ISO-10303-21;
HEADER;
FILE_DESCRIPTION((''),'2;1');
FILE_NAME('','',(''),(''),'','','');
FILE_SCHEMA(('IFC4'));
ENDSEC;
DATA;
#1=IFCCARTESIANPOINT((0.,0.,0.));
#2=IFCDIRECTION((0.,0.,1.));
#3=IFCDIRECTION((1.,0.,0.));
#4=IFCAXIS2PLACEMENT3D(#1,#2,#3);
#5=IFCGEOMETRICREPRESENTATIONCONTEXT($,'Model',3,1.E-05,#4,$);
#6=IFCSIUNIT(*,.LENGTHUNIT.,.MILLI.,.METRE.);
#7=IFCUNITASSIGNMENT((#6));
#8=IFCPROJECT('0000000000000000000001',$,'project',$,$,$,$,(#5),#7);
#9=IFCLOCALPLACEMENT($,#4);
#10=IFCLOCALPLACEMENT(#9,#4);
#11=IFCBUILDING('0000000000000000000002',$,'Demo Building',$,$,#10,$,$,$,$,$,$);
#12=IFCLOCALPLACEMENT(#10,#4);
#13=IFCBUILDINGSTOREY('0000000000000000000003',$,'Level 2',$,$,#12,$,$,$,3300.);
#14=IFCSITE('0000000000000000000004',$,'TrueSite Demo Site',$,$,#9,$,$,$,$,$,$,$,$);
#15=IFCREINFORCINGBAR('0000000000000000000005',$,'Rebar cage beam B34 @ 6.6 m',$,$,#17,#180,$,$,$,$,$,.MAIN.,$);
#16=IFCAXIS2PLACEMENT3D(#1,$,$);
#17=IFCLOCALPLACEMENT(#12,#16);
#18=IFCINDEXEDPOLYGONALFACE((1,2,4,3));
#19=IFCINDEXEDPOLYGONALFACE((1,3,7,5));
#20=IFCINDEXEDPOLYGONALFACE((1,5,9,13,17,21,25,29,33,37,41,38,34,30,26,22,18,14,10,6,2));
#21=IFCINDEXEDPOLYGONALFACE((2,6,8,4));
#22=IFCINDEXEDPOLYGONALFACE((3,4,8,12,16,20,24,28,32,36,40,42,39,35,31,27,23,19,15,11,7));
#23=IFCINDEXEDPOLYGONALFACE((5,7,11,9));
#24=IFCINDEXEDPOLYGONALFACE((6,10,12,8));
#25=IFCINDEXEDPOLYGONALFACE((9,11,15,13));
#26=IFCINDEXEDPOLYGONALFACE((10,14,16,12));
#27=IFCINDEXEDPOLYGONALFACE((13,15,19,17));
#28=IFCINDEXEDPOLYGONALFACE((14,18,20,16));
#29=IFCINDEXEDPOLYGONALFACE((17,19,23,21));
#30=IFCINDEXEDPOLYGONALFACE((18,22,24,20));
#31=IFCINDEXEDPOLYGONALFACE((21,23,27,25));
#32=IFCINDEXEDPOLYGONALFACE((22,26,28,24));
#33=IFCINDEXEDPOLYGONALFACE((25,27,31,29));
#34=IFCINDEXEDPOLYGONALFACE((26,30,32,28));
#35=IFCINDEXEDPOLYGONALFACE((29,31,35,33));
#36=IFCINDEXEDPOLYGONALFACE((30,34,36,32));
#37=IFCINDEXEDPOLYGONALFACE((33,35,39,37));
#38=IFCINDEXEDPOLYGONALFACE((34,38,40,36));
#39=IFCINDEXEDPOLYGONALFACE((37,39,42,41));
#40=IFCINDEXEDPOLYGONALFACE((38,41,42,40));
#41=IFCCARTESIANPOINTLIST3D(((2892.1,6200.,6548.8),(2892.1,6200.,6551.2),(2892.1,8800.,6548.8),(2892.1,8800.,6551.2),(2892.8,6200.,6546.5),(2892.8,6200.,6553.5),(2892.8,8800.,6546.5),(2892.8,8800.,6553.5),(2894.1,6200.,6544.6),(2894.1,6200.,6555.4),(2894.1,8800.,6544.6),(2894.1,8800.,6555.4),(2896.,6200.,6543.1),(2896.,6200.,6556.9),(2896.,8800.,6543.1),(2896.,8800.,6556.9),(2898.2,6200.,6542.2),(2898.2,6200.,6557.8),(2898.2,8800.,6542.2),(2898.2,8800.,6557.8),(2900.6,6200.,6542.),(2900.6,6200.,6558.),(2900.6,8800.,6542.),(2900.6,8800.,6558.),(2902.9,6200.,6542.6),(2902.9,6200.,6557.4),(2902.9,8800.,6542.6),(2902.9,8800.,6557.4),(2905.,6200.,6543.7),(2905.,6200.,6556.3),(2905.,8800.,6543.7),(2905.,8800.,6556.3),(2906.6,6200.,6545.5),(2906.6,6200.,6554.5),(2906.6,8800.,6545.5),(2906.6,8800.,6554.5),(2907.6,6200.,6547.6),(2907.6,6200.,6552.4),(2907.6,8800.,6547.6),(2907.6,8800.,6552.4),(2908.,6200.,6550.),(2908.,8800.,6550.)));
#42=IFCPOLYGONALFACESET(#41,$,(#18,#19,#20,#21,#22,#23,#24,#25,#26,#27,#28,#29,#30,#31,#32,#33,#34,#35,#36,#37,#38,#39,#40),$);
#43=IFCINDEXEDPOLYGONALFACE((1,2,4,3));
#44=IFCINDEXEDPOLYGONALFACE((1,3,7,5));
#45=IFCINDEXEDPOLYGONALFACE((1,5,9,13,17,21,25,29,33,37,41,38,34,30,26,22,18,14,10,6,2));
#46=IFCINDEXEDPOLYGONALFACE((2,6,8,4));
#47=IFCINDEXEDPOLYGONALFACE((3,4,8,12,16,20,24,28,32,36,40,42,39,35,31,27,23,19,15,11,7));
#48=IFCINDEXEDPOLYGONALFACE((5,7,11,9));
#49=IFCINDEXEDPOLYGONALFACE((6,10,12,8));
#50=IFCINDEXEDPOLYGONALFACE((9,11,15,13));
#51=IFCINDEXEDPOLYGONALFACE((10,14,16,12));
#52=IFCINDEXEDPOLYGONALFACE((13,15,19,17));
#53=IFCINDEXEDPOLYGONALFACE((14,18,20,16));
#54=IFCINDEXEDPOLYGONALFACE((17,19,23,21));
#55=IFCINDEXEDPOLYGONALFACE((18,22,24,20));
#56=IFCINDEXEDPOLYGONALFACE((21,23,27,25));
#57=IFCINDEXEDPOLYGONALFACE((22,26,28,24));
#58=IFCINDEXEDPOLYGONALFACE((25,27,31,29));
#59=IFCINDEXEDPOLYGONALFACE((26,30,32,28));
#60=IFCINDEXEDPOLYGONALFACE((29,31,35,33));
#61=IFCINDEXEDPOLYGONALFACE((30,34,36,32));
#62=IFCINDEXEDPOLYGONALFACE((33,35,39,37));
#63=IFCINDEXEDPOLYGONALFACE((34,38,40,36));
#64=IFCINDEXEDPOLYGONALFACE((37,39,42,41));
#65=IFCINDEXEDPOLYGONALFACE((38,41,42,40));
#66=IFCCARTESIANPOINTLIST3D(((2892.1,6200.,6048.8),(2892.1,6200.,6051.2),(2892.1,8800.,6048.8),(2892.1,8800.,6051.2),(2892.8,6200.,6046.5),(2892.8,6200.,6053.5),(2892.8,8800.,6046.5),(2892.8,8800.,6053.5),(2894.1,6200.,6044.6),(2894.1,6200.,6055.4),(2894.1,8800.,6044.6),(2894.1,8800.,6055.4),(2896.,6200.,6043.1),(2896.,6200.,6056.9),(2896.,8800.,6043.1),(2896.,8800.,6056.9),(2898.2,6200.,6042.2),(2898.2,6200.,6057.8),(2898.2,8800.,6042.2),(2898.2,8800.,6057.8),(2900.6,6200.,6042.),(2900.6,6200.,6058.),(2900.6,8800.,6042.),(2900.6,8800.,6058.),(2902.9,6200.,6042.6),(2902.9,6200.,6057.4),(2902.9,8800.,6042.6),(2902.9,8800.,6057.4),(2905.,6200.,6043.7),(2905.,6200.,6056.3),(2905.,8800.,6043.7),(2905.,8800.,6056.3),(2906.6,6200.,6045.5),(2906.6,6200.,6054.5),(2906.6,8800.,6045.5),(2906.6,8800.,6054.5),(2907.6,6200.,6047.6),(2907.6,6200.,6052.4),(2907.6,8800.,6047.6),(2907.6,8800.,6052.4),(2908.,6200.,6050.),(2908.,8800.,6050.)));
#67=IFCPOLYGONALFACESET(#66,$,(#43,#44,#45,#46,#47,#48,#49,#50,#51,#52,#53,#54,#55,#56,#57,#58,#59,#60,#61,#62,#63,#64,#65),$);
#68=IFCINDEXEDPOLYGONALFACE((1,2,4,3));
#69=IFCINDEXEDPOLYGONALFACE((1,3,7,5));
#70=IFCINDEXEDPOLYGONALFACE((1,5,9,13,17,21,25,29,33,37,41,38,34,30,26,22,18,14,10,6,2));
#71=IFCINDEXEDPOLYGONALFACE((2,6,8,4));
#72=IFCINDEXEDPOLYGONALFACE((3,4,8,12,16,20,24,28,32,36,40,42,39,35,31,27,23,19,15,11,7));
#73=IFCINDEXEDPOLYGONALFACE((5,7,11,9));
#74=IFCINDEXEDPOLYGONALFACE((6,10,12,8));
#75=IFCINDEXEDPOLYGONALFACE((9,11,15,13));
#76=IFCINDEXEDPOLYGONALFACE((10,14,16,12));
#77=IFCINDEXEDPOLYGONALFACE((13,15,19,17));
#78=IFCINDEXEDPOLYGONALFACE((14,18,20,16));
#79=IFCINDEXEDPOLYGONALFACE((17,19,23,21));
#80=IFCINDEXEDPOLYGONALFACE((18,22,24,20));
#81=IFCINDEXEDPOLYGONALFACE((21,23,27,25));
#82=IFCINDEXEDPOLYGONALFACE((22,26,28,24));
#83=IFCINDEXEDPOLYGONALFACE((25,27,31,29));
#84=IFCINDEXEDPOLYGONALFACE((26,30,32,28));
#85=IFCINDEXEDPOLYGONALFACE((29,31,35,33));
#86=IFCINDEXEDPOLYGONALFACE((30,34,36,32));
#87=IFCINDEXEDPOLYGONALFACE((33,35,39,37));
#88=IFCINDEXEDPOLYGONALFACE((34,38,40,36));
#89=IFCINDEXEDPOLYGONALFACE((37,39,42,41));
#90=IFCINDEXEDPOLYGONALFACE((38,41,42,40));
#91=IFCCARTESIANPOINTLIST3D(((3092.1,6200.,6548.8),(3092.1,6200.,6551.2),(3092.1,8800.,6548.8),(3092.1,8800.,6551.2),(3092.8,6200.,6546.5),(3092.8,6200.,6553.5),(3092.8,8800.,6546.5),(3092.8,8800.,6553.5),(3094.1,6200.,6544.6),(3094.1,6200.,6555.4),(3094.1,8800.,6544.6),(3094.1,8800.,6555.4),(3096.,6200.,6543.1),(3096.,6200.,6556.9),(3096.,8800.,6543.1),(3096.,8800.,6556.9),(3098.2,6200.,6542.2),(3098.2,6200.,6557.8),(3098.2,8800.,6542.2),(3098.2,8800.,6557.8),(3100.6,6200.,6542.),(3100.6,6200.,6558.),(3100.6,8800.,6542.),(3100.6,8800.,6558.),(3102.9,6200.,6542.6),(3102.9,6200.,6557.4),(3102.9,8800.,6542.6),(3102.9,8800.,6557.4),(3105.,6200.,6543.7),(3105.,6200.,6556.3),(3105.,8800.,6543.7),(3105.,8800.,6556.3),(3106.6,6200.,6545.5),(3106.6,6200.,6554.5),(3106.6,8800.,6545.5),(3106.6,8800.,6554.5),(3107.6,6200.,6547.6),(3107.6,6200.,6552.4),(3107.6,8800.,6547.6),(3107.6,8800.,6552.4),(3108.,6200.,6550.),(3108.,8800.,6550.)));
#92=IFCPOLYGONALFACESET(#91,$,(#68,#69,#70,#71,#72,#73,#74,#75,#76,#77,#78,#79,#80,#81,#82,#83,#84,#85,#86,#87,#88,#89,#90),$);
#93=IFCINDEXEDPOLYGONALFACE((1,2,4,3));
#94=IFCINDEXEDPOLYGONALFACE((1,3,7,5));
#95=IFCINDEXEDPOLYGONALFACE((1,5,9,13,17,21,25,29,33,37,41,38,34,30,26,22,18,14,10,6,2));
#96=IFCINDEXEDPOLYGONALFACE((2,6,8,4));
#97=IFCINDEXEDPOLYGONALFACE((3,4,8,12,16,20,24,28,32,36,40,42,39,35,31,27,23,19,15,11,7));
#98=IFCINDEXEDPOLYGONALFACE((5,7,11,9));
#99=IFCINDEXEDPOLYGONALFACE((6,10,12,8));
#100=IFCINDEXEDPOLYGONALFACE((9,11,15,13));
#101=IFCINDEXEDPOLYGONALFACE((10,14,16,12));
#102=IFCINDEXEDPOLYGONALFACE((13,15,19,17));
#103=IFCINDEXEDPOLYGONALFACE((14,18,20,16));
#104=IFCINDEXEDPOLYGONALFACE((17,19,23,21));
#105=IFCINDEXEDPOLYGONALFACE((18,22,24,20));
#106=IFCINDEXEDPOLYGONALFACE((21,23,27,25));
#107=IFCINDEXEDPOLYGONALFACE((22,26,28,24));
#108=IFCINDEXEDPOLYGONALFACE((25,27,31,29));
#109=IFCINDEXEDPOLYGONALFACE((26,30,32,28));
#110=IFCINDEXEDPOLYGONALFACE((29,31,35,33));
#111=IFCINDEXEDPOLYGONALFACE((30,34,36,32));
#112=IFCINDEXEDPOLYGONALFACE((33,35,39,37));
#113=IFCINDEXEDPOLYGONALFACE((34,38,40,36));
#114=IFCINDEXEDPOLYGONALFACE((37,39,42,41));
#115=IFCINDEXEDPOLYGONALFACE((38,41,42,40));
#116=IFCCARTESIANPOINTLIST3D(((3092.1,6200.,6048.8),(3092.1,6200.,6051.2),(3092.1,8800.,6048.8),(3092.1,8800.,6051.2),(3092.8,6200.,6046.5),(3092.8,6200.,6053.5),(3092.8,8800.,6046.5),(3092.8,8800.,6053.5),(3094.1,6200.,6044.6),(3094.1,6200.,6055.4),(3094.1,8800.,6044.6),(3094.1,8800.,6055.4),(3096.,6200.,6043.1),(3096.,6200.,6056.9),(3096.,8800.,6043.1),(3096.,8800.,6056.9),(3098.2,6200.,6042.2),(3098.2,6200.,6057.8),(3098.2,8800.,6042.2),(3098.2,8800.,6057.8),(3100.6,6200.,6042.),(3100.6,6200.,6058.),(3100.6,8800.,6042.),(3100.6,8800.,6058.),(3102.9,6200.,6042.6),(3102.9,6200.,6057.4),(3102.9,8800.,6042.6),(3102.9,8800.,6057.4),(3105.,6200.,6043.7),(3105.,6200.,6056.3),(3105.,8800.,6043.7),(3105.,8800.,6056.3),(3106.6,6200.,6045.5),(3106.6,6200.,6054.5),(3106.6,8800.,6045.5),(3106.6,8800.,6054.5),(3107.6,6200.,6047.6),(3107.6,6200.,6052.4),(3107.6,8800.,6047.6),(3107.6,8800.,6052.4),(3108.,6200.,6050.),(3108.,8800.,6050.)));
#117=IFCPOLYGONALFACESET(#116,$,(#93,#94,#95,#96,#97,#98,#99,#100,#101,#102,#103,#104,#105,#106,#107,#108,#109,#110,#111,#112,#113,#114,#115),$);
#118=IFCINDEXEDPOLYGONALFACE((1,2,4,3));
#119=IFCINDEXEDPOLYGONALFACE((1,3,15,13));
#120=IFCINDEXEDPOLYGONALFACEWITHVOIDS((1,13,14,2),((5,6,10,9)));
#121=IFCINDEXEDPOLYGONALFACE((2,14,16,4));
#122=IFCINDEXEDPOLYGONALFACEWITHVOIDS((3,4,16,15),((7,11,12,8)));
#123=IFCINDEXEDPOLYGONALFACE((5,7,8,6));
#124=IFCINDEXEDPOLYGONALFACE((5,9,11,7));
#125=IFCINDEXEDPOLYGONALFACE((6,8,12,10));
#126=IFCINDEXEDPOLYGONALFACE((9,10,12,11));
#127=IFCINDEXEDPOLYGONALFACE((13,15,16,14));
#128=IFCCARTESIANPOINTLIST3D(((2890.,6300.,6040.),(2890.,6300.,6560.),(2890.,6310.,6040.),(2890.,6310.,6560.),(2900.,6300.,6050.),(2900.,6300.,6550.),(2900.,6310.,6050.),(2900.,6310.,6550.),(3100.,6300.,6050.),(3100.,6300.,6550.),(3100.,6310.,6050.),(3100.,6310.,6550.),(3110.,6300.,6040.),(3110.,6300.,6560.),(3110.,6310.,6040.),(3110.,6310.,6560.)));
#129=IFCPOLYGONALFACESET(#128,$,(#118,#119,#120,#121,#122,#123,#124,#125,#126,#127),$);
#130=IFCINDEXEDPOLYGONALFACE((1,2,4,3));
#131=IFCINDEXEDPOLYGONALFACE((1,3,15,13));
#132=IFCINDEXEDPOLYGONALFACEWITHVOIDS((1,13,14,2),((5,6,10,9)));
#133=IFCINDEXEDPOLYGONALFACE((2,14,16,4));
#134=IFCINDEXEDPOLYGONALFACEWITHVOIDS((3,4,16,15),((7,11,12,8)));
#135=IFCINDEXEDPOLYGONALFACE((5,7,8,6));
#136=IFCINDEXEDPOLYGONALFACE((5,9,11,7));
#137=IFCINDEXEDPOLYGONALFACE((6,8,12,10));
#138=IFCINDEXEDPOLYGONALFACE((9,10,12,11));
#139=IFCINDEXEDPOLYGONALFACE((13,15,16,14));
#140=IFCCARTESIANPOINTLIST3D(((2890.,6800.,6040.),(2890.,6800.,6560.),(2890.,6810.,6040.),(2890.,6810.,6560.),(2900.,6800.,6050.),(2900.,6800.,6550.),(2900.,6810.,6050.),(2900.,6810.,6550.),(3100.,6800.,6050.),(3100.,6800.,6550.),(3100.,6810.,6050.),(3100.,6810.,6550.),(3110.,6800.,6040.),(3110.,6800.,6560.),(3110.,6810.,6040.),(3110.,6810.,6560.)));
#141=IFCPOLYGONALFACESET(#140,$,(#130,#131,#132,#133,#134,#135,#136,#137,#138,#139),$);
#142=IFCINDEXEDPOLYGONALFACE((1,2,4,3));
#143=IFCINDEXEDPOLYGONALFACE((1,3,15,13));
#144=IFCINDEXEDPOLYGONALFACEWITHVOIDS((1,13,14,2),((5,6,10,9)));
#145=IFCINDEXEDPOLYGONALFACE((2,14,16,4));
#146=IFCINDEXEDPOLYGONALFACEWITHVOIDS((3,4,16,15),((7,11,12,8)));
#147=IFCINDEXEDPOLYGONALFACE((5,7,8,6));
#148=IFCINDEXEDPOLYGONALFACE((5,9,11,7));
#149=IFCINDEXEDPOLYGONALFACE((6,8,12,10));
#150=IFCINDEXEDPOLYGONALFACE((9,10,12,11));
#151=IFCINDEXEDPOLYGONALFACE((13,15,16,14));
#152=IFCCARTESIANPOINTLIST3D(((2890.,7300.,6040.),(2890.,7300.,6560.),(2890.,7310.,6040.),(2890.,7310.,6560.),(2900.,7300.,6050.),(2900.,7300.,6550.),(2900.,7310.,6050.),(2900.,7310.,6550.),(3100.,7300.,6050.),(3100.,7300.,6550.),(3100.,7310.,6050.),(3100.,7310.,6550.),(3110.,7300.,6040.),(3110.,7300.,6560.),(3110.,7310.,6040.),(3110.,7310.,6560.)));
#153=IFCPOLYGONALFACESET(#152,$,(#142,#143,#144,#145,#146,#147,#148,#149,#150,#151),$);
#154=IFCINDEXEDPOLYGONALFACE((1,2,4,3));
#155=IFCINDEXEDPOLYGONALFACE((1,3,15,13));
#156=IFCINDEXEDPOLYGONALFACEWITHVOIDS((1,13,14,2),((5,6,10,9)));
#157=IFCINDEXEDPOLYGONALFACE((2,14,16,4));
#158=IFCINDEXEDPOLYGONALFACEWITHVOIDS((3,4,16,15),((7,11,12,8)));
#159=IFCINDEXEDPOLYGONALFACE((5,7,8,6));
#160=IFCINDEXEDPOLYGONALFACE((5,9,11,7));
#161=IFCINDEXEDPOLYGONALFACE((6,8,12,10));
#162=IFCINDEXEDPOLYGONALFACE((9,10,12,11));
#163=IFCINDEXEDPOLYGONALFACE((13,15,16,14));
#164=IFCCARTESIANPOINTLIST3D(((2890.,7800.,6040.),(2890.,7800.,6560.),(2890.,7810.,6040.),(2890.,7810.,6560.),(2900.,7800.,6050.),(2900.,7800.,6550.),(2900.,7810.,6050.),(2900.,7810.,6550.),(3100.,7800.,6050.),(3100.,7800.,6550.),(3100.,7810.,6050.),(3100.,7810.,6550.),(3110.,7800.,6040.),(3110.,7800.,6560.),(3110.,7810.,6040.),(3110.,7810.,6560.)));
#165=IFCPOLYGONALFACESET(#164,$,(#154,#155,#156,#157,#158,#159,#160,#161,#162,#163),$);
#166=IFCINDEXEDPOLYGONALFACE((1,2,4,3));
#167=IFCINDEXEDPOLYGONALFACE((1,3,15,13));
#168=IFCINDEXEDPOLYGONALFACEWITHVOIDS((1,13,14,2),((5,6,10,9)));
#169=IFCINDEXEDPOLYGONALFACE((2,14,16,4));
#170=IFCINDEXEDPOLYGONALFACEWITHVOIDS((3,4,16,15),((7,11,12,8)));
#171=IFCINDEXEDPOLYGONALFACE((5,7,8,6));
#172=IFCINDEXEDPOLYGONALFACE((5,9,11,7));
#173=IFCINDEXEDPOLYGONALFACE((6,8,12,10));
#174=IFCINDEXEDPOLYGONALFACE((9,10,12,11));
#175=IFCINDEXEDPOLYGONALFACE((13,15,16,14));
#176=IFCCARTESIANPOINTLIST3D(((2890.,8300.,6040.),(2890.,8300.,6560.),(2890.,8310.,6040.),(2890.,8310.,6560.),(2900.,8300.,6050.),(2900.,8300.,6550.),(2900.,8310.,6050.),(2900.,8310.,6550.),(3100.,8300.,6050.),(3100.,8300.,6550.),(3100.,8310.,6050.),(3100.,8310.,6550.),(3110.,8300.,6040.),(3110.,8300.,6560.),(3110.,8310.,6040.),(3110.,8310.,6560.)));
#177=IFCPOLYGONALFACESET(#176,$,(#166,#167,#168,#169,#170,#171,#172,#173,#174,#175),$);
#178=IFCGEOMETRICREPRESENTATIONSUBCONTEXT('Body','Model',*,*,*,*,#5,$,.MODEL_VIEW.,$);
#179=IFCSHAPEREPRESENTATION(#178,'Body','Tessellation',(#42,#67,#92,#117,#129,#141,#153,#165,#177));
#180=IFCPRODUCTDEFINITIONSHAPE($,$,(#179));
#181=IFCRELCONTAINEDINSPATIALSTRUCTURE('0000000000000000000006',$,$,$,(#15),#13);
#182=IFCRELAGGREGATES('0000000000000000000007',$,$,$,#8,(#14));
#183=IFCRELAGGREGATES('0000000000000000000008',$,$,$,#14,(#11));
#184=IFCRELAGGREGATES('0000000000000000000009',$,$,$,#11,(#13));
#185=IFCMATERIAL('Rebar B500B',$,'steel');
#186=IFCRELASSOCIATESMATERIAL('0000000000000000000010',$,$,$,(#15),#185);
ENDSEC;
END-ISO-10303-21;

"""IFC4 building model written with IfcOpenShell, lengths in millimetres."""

from ifc_helpers import new_model, si_unit, frame, origin_with_axes, place, context, subcontext, project, spatial, hollow_rectangle, circle, extrude, material, element, save


model = new_model("IFC4")

# Units and contexts
model_context = context("Model", 3, precision=1e-05, world=origin_with_axes())
body_context = subcontext(model_context, "Body", "Model", "MODEL_VIEW")
ifc_project = project(units=[si_unit("LENGTHUNIT", "METRE", prefix="MILLI")], contexts=[model_context])

# Site, building, storey
site_placement = place(None, origin_with_axes())
site = spatial("IfcSite", under=ifc_project, at=site_placement, Name="TrueSite Demo Site")
building_placement = place(site_placement, origin_with_axes())
building = spatial("IfcBuilding", under=site, at=building_placement, Name="Demo Building")
storey_placement = place(building_placement, origin_with_axes())
storey = spatial("IfcBuildingStorey", under=building, at=storey_placement, Name="Level 2", Elevation=3300.0)

# Reinforcing bar
ifc_material_1 = material(Name="Rebar B500B", Category="steel")
reinforcing_bar_1_placement = place(storey_placement, frame((3000.0, 6200.0, 6300.0), z_axis=(0.0, 1.0, 0.0), x_axis=(1.0, 0.0, 0.0)))
element("IfcReinforcingBar", 1, at=reinforcing_bar_1_placement, inside=storey, material=ifc_material_1, Name="Rebar cage beam B34 @ 6.6 m", PredefinedType="MAIN", context=body_context, shape_type="SweptSolid", body=[
    extrude(circle(Radius=8.0), frame((-100.0, -250.0, 0.0)), (0.0, 0.0, 1.0), 2600.0),
    extrude(circle(Radius=8.0), frame((-100.0, 250.0, 0.0)), (0.0, 0.0, 1.0), 2600.0),
    extrude(circle(Radius=8.0), frame((100.0, -250.0, 0.0)), (0.0, 0.0, 1.0), 2600.0),
    extrude(circle(Radius=8.0), frame((100.0, 250.0, 0.0)), (0.0, 0.0, 1.0), 2600.0),
    extrude(hollow_rectangle(XDim=220.0, YDim=520.0, WallThickness=10.0), frame((0.0, 0.0, 100.0)), (0.0, 0.0, 1.0), 10.0),
    extrude(hollow_rectangle(XDim=220.0, YDim=520.0, WallThickness=10.0), frame((0.0, 0.0, 600.0)), (0.0, 0.0, 1.0), 10.0),
    extrude(hollow_rectangle(XDim=220.0, YDim=520.0, WallThickness=10.0), frame((0.0, 0.0, 1100.0)), (0.0, 0.0, 1.0), 10.0),
    extrude(hollow_rectangle(XDim=220.0, YDim=520.0, WallThickness=10.0), frame((0.0, 0.0, 1600.0)), (0.0, 0.0, 1.0), 10.0),
    extrude(hollow_rectangle(XDim=220.0, YDim=520.0, WallThickness=10.0), frame((0.0, 0.0, 2100.0)), (0.0, 0.0, 1.0), 10.0),
])

save(model, "model.ifc")
